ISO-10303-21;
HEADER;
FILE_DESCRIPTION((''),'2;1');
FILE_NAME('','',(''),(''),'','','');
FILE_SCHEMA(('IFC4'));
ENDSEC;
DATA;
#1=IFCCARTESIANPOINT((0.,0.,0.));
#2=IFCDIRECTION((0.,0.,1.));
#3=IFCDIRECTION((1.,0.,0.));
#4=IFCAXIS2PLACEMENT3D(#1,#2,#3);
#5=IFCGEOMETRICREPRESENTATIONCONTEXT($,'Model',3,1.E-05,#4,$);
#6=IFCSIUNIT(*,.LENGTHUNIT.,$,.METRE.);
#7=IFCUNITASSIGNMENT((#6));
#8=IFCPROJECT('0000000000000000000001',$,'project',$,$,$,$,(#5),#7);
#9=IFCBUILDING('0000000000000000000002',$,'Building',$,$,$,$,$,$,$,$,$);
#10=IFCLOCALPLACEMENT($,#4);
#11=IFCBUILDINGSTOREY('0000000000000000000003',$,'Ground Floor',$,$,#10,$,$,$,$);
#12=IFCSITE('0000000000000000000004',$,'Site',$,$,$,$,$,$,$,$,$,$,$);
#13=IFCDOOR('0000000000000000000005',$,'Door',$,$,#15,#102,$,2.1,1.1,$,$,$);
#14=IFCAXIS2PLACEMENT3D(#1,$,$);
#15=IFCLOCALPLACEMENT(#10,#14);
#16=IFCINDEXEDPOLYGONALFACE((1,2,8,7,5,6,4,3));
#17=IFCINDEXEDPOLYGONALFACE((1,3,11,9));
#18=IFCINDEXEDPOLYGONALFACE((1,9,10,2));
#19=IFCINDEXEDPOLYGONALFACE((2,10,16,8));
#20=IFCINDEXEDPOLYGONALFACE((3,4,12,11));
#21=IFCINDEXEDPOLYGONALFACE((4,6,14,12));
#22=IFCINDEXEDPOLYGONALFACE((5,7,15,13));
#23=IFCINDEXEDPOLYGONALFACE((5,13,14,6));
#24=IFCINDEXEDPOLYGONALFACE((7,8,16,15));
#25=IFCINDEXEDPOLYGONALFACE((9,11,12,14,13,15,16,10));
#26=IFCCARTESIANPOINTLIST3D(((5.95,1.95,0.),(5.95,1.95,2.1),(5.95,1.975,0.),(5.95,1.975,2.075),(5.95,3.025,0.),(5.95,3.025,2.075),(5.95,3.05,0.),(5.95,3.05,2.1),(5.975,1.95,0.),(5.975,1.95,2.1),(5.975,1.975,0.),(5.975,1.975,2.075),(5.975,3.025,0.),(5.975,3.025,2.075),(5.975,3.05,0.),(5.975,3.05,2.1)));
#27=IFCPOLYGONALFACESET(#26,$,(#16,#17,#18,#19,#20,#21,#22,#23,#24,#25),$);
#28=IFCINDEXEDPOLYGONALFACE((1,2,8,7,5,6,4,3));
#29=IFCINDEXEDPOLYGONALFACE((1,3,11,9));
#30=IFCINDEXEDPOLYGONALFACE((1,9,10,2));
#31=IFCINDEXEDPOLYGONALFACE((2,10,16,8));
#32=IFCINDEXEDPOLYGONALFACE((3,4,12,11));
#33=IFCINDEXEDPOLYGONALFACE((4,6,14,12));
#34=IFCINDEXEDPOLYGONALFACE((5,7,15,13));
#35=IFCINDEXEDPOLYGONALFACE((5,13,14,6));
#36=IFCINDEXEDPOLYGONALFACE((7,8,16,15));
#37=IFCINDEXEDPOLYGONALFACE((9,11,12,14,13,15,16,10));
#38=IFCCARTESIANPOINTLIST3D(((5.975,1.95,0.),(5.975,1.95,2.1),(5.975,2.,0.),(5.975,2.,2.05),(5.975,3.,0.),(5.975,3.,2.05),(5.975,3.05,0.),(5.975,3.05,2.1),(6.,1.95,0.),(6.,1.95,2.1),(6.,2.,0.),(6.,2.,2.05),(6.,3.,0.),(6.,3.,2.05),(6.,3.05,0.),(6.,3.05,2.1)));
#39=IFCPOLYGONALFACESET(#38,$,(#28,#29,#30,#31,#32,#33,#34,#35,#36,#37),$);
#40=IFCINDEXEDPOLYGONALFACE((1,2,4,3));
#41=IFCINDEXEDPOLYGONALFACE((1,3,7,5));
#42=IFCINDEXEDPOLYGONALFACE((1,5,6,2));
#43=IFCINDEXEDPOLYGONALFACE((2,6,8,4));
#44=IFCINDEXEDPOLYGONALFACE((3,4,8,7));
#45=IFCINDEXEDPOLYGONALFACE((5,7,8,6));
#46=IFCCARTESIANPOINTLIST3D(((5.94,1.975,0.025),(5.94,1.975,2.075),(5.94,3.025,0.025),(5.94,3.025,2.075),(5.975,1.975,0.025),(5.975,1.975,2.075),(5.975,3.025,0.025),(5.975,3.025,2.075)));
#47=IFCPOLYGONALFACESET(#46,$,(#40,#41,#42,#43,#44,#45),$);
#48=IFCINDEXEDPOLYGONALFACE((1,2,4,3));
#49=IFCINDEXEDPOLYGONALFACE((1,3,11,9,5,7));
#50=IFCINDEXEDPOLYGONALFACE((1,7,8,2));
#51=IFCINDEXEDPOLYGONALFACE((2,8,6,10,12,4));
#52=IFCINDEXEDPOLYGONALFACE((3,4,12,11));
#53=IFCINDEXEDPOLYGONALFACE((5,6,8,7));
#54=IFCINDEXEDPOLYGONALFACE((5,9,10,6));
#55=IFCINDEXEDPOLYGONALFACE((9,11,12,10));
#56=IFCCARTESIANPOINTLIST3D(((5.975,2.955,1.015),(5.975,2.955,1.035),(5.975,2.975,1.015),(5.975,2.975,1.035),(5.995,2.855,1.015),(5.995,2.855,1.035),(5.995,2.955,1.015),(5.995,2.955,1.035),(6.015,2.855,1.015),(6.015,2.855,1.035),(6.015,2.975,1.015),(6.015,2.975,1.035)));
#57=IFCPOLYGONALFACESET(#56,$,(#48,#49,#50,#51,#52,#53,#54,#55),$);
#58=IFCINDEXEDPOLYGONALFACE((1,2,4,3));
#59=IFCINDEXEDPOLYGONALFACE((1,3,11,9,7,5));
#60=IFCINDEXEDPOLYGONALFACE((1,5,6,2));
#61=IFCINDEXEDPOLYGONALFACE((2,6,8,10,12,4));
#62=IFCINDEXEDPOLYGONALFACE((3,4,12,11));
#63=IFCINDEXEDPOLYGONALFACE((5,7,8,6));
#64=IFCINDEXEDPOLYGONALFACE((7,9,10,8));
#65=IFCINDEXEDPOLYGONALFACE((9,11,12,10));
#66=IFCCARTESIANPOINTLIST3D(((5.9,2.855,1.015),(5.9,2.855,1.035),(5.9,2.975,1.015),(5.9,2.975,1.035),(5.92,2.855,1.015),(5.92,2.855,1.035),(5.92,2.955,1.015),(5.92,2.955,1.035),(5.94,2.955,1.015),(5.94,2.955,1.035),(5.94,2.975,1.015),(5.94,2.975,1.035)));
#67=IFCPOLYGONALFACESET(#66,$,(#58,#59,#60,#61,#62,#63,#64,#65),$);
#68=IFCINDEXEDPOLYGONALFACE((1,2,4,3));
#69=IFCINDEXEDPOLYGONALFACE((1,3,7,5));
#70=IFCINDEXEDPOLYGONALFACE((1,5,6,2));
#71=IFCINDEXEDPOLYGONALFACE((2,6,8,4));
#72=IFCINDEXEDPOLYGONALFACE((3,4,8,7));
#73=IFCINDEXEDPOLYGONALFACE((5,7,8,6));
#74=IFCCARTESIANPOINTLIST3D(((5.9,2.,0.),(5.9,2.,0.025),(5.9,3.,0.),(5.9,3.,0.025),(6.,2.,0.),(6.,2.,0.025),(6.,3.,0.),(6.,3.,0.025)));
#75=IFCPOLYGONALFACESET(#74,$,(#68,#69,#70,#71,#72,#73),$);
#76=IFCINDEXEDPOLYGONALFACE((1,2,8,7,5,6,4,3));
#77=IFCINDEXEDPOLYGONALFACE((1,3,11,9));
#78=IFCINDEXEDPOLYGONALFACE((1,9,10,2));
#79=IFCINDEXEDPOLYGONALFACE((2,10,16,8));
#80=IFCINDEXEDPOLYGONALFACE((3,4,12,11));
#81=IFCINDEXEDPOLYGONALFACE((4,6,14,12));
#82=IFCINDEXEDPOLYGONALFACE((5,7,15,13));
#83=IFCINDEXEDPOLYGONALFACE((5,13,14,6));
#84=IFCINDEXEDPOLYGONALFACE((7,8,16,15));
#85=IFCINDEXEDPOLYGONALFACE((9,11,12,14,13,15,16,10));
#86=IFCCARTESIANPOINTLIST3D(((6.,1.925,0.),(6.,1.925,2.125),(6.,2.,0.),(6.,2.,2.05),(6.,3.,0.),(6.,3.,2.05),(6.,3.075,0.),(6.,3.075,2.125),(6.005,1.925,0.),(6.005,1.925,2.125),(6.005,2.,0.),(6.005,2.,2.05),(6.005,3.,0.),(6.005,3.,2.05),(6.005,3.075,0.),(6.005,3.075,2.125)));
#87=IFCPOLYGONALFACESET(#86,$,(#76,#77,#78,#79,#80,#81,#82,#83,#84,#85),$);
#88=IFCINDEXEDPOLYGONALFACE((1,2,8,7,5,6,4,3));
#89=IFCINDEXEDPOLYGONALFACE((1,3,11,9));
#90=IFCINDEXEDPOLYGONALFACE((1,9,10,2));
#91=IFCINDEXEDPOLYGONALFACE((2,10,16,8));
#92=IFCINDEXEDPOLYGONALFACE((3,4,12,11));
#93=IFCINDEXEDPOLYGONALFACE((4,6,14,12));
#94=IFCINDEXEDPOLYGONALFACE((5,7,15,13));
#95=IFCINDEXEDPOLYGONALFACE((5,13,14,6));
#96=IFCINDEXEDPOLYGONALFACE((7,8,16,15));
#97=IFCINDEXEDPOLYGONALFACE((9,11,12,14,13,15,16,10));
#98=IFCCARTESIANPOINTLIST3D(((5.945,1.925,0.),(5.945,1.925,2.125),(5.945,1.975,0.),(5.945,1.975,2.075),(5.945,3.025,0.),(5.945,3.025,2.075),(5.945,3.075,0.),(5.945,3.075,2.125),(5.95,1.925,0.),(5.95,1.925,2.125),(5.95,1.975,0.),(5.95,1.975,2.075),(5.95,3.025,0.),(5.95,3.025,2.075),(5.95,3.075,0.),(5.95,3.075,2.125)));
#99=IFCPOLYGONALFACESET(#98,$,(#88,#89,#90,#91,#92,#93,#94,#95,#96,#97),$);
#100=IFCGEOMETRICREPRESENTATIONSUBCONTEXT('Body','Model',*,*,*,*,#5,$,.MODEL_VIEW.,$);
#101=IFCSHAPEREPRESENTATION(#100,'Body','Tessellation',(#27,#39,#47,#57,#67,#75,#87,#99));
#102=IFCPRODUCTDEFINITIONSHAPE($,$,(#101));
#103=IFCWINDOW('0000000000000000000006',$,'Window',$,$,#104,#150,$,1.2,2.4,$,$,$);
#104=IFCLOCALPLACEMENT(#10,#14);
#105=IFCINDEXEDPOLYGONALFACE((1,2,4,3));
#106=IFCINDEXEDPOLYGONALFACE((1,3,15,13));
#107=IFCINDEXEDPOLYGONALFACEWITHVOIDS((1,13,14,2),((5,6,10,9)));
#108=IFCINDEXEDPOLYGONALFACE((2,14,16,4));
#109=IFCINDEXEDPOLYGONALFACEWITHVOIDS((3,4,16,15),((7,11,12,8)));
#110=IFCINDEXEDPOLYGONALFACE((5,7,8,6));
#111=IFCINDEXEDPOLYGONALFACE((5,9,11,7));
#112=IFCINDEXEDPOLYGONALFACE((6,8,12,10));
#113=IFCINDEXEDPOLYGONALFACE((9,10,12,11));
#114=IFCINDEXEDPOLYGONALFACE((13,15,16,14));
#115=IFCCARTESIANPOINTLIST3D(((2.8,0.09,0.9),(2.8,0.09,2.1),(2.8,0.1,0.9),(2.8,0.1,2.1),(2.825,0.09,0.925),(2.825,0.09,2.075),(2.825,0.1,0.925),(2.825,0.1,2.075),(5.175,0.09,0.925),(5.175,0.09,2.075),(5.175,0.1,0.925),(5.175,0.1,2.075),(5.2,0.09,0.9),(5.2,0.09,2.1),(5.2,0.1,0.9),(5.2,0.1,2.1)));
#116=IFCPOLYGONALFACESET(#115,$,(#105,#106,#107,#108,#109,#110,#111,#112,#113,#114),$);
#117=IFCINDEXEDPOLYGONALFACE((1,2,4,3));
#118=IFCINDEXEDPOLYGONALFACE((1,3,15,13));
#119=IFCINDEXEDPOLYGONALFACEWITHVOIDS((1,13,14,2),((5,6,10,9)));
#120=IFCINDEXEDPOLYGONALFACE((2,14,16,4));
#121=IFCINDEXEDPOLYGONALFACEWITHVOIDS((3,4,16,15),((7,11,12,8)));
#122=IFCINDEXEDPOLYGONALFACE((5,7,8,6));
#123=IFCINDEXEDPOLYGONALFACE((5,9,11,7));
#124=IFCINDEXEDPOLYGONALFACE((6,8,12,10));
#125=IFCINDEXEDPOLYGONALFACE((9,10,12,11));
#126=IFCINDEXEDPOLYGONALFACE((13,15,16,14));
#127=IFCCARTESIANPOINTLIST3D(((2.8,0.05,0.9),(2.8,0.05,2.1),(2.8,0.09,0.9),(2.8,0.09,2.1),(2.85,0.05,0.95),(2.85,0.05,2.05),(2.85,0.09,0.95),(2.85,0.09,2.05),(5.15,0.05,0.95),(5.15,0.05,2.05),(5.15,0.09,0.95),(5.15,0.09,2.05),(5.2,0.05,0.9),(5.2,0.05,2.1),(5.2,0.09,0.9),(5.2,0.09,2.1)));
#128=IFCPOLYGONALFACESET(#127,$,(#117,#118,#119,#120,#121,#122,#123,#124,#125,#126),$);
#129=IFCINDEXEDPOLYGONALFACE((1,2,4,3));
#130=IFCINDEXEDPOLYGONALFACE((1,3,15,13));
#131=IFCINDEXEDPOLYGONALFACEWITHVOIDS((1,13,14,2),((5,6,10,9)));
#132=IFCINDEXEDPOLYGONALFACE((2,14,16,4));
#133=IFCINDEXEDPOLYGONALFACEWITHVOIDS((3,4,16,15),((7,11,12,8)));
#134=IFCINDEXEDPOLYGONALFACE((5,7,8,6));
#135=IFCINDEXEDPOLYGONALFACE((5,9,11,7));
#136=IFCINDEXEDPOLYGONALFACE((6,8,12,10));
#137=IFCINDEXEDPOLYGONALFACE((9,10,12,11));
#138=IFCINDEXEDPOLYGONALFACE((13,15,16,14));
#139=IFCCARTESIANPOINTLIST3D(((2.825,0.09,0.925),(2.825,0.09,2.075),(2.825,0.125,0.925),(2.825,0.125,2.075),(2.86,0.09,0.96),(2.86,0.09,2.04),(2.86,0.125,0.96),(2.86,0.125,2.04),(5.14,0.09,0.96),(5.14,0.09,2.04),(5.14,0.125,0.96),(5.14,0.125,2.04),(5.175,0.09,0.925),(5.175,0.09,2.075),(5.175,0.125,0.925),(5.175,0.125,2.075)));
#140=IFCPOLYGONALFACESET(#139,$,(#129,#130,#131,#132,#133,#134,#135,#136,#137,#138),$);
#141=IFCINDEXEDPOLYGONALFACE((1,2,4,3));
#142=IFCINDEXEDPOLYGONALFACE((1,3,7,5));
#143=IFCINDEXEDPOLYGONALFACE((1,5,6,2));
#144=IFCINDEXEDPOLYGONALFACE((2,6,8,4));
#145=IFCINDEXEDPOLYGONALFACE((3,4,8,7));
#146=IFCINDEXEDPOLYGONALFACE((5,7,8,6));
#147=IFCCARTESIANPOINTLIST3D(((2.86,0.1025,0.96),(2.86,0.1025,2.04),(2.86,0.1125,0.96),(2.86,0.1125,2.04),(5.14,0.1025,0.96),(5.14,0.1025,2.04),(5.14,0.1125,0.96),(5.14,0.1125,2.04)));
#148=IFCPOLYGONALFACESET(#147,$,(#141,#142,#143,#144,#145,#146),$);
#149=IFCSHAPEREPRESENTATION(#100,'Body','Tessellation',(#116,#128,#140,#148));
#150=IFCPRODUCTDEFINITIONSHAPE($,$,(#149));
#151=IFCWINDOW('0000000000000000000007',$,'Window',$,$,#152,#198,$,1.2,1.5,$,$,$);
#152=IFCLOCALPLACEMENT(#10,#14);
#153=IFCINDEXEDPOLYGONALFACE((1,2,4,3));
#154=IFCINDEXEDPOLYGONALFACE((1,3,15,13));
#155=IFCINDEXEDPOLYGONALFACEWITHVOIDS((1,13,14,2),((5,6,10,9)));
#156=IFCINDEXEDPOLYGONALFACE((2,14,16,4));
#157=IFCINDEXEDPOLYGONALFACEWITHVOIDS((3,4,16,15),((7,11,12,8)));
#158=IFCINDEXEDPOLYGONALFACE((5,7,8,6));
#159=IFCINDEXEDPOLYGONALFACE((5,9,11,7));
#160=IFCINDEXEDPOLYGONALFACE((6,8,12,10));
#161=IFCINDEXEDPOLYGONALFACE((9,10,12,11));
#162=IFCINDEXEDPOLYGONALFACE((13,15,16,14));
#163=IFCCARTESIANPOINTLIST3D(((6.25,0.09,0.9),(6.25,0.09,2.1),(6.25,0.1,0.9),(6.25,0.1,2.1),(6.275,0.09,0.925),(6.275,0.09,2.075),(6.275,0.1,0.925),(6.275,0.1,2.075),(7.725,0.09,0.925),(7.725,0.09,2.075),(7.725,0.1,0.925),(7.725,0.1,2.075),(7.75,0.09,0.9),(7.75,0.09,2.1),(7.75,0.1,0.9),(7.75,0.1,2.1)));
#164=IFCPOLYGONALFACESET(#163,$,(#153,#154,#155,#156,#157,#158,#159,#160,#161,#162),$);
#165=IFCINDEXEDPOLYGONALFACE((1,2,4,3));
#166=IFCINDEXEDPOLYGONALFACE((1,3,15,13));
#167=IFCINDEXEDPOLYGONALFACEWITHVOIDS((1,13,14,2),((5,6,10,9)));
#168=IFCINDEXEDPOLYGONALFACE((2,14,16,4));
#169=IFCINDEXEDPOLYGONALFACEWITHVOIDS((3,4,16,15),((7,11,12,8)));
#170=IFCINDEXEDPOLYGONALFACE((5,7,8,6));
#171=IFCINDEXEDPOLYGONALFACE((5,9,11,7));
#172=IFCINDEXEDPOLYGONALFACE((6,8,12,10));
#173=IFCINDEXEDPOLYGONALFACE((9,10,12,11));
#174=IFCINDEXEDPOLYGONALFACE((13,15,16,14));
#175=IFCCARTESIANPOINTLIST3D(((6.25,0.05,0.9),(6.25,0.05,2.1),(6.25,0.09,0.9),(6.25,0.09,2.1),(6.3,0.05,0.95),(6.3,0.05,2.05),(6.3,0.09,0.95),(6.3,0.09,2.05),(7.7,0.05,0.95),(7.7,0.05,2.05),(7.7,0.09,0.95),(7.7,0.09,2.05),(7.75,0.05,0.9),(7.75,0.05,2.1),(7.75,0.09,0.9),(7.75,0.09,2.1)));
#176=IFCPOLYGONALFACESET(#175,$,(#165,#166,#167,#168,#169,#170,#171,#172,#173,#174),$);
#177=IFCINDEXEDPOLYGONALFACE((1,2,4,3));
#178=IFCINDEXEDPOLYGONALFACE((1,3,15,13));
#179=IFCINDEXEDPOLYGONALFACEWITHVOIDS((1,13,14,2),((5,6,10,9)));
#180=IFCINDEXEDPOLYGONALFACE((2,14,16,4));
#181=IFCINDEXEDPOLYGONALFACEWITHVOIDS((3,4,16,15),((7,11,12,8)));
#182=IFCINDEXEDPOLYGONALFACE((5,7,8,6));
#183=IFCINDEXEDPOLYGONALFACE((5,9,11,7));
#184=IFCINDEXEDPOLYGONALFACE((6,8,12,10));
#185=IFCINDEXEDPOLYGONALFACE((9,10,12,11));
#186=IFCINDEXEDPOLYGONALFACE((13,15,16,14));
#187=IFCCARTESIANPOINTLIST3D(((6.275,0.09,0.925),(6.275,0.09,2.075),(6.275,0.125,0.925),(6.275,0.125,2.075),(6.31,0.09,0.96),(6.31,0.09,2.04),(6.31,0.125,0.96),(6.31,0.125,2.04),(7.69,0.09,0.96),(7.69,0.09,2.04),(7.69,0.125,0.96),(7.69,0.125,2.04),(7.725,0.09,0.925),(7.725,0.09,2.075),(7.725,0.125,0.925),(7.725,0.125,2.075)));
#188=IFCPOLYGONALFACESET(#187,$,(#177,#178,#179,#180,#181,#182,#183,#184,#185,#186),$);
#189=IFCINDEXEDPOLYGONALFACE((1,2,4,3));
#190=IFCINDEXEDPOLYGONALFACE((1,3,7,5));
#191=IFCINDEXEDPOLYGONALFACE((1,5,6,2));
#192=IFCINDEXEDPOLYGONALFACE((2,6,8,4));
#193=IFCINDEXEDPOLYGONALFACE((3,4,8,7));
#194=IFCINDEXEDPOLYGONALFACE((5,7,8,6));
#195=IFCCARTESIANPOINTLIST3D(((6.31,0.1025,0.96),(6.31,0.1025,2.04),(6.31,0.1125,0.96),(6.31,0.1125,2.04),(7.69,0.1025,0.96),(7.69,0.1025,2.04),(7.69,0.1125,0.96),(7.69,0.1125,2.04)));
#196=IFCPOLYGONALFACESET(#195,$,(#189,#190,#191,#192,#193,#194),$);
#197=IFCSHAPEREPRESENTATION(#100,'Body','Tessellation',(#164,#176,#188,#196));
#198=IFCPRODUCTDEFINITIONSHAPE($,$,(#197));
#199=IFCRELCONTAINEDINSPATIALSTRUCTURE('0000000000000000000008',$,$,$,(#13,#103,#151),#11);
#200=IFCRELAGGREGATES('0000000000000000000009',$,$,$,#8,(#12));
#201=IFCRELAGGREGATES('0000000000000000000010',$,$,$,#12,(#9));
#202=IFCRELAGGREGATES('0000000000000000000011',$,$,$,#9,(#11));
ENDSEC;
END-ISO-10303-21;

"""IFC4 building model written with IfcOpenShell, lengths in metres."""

from ifc_helpers import new_model, si_unit, frame, origin_with_axes, place, context, subcontext, project, spatial, line, indexed_curve, outline, extrude, element, save


model = new_model("IFC4")

# Units and contexts
model_context = context("Model", 3, precision=1e-05, world=origin_with_axes())
body_context = subcontext(model_context, "Body", "Model", "MODEL_VIEW")
ifc_project = project(units=[si_unit("LENGTHUNIT", "METRE")], contexts=[model_context])

# Site, building, storey
site = spatial("IfcSite", under=ifc_project, Name="Site")
building = spatial("IfcBuilding", under=site, Name="Building")
storey_placement = place(None, origin_with_axes())
storey = spatial("IfcBuildingStorey", under=building, at=storey_placement, Name="Ground Floor")

# Door
door_1_placement = place(storey_placement, frame((6.0, 1.95, 0.0), z_axis=(0.0, 0.0, 1.0), x_axis=(0.0, 1.0, 0.0)))
element("IfcDoor", 1, at=door_1_placement, inside=storey, Name="Door", OverallHeight=2.1, OverallWidth=1.1, context=body_context, shape_type="SweptSolid", body=[
    extrude(outline(indexed_curve([(0.0, 0.0), (0.0, 2.1), (1.1, 2.1), (1.1, 0.0), (1.075, 0.0), (1.075, 2.075), (0.025, 2.075), (0.025, 0.0)], segments=[line(1, 2, 3, 4, 5, 6, 7, 8, 1)])), frame((0.0, 0.025, 0.0), z_axis=(0.0, -1.0, 0.0), x_axis=(1.0, 0.0, 0.0)), (0.0, 0.0, -1.0), 0.025),
    extrude(outline(indexed_curve([(0.0, 0.0), (0.0, 2.1), (1.1, 2.1), (1.1, 0.0), (1.05, 0.0), (1.05, 2.05), (0.05, 2.05), (0.05, 0.0)], segments=[line(1, 2, 3, 4, 5, 6, 7, 8, 1)])), frame((0.0, 0.0, 0.0), z_axis=(0.0, -1.0, 0.0), x_axis=(1.0, 0.0, 0.0)), (0.0, 0.0, -1.0), 0.025),
    extrude(outline(indexed_curve([(0.0, 0.0), (1.05, 0.0), (1.05, 0.035), (0.0, 0.035)], segments=[line(1, 2, 3, 4, 1)])), frame((0.025, 0.025, 0.025), z_axis=(0.0, 0.0, 1.0), x_axis=(1.0, 0.0, 0.0)), (0.0, 0.0, 1.0), 2.05),
    extrude(outline(indexed_curve([(0.0, 0.0), (0.0, -0.04), (-0.12, -0.04), (-0.12, -0.02), (-0.02, -0.02), (-0.02, 0.0)], segments=[line(1, 2, 3, 4, 5, 6, 1)])), frame((1.025, 0.025, 1.015), z_axis=(0.0, 0.0, 1.0), x_axis=(1.0, 0.0, 0.0)), (0.0, 0.0, 1.0), 0.02),
    extrude(outline(indexed_curve([(0.0, 0.0), (0.0, 0.04), (-0.12, 0.04), (-0.12, 0.02), (-0.02, 0.02), (-0.02, 0.0)], segments=[line(1, 2, 3, 4, 5, 6, 1)])), frame((1.025, 0.06, 1.015), z_axis=(0.0, 0.0, 1.0), x_axis=(1.0, 0.0, 0.0)), (0.0, 0.0, 1.0), 0.02),
    extrude(outline(indexed_curve([(0.0, 0.0), (1.0, 0.0), (1.0, 0.1), (0.0, 0.1)], segments=[line(1, 2, 3, 4, 1)])), frame((0.05, 0.0, 0.0), z_axis=(0.0, 0.0, 1.0), x_axis=(1.0, 0.0, 0.0)), (0.0, 0.0, 1.0), 0.025),
    extrude(outline(indexed_curve([(0.0, 0.0), (0.0, 2.125), (1.15, 2.125), (1.15, 0.0), (1.075, 0.0), (1.075, 2.05), (0.075, 2.05), (0.075, 0.0)], segments=[line(1, 2, 3, 4, 5, 6, 7, 8, 1)])), frame((-0.025, -0.005, 0.0), z_axis=(0.0, -1.0, 0.0), x_axis=(1.0, 0.0, 0.0)), (0.0, 0.0, -1.0), 0.005),
    extrude(outline(indexed_curve([(0.0, 0.0), (0.0, 2.125), (1.15, 2.125), (1.15, 0.0), (1.1, 0.0), (1.1, 2.075), (0.05, 2.075), (0.05, 0.0)], segments=[line(1, 2, 3, 4, 5, 6, 7, 8, 1)])), frame((-0.025, 0.05, 0.0), z_axis=(0.0, -1.0, 0.0), x_axis=(1.0, 0.0, 0.0)), (0.0, 0.0, -1.0), 0.005),
])

# Windows
window_1_placement = place(storey_placement, frame((2.8, 0.0, 0.9), z_axis=(0.0, 0.0, 1.0), x_axis=(1.0, 0.0, 0.0)))
element("IfcWindow", 2, at=window_1_placement, inside=storey, Name="Window", OverallHeight=1.2, OverallWidth=2.4, context=body_context, shape_type="SweptSolid", body=[
    extrude(outline(indexed_curve([(0.0, 0.0), (2.4, 0.0), (2.4, 1.2), (0.0, 1.2)], segments=[line(1, 2, 3, 4, 1)]), holes=[indexed_curve([(0.025, 0.025), (2.375, 0.025), (2.375, 1.175), (0.025, 1.175)], segments=[line(1, 2, 3, 4, 1)])]), frame((0.0, 0.09, 0.0), z_axis=(0.0, -1.0, 0.0), x_axis=(1.0, 0.0, 0.0)), (0.0, 0.0, -1.0), 0.01),
    extrude(outline(indexed_curve([(0.0, 0.0), (2.4, 0.0), (2.4, 1.2), (0.0, 1.2)], segments=[line(1, 2, 3, 4, 1)]), holes=[indexed_curve([(0.05, 0.05), (2.35, 0.05), (2.35, 1.15), (0.05, 1.15)], segments=[line(1, 2, 3, 4, 1)])]), frame((0.0, 0.05, 0.0), z_axis=(0.0, -1.0, 0.0), x_axis=(1.0, 0.0, 0.0)), (0.0, 0.0, -1.0), 0.04),
    extrude(outline(indexed_curve([(0.0, 0.0), (2.35, 0.0), (2.35, 1.15), (0.0, 1.15)], segments=[line(1, 2, 3, 4, 1)]), holes=[indexed_curve([(0.035, 0.035), (2.315, 0.035), (2.315, 1.115), (0.035, 1.115)], segments=[line(1, 2, 3, 4, 1)])]), frame((0.025, 0.09, 0.025), z_axis=(0.0, -1.0, 0.0), x_axis=(1.0, 0.0, 0.0)), (0.0, 0.0, -1.0), 0.035),
    extrude(outline(indexed_curve([(0.035, 0.035), (2.315, 0.035), (2.315, 1.115), (0.035, 1.115)], segments=[line(1, 2, 3, 4, 1)])), frame((0.025, 0.1025, 0.025), z_axis=(0.0, -1.0, 0.0), x_axis=(1.0, 0.0, 0.0)), (0.0, 0.0, -1.0), 0.01),
])
for number, where, z_axis, x_axis, name in (
    (3, (6.25, 0.0, 0.9), (0.0, 0.0, 1.0), (1.0, 0.0, 0.0), "Window"),
):
    element("IfcWindow", number, at=place(storey_placement, frame(where, z_axis=z_axis, x_axis=x_axis)), inside=storey, Name=name, OverallHeight=1.2, OverallWidth=1.5, context=body_context, shape_type="SweptSolid", body=[
        extrude(outline(indexed_curve([(0.0, 0.0), (1.5, 0.0), (1.5, 1.2), (0.0, 1.2)], segments=[line(1, 2, 3, 4, 1)]), holes=[indexed_curve([(0.025, 0.025), (1.475, 0.025), (1.475, 1.175), (0.025, 1.175)], segments=[line(1, 2, 3, 4, 1)])]), frame((0.0, 0.09, 0.0), z_axis=(0.0, -1.0, 0.0), x_axis=(1.0, 0.0, 0.0)), (0.0, 0.0, -1.0), 0.01),
        extrude(outline(indexed_curve([(0.0, 0.0), (1.5, 0.0), (1.5, 1.2), (0.0, 1.2)], segments=[line(1, 2, 3, 4, 1)]), holes=[indexed_curve([(0.05, 0.05), (1.45, 0.05), (1.45, 1.15), (0.05, 1.15)], segments=[line(1, 2, 3, 4, 1)])]), frame((0.0, 0.05, 0.0), z_axis=(0.0, -1.0, 0.0), x_axis=(1.0, 0.0, 0.0)), (0.0, 0.0, -1.0), 0.04),
        extrude(outline(indexed_curve([(0.0, 0.0), (1.45, 0.0), (1.45, 1.15), (0.0, 1.15)], segments=[line(1, 2, 3, 4, 1)]), holes=[indexed_curve([(0.035, 0.035), (1.415, 0.035), (1.415, 1.115), (0.035, 1.115)], segments=[line(1, 2, 3, 4, 1)])]), frame((0.025, 0.09, 0.025), z_axis=(0.0, -1.0, 0.0), x_axis=(1.0, 0.0, 0.0)), (0.0, 0.0, -1.0), 0.035),
        extrude(outline(indexed_curve([(0.035, 0.035), (1.415, 0.035), (1.415, 1.115), (0.035, 1.115)], segments=[line(1, 2, 3, 4, 1)])), frame((0.025, 0.1025, 0.025), z_axis=(0.0, -1.0, 0.0), x_axis=(1.0, 0.0, 0.0)), (0.0, 0.0, -1.0), 0.01),
    ])

save(model, "model.ifc")
